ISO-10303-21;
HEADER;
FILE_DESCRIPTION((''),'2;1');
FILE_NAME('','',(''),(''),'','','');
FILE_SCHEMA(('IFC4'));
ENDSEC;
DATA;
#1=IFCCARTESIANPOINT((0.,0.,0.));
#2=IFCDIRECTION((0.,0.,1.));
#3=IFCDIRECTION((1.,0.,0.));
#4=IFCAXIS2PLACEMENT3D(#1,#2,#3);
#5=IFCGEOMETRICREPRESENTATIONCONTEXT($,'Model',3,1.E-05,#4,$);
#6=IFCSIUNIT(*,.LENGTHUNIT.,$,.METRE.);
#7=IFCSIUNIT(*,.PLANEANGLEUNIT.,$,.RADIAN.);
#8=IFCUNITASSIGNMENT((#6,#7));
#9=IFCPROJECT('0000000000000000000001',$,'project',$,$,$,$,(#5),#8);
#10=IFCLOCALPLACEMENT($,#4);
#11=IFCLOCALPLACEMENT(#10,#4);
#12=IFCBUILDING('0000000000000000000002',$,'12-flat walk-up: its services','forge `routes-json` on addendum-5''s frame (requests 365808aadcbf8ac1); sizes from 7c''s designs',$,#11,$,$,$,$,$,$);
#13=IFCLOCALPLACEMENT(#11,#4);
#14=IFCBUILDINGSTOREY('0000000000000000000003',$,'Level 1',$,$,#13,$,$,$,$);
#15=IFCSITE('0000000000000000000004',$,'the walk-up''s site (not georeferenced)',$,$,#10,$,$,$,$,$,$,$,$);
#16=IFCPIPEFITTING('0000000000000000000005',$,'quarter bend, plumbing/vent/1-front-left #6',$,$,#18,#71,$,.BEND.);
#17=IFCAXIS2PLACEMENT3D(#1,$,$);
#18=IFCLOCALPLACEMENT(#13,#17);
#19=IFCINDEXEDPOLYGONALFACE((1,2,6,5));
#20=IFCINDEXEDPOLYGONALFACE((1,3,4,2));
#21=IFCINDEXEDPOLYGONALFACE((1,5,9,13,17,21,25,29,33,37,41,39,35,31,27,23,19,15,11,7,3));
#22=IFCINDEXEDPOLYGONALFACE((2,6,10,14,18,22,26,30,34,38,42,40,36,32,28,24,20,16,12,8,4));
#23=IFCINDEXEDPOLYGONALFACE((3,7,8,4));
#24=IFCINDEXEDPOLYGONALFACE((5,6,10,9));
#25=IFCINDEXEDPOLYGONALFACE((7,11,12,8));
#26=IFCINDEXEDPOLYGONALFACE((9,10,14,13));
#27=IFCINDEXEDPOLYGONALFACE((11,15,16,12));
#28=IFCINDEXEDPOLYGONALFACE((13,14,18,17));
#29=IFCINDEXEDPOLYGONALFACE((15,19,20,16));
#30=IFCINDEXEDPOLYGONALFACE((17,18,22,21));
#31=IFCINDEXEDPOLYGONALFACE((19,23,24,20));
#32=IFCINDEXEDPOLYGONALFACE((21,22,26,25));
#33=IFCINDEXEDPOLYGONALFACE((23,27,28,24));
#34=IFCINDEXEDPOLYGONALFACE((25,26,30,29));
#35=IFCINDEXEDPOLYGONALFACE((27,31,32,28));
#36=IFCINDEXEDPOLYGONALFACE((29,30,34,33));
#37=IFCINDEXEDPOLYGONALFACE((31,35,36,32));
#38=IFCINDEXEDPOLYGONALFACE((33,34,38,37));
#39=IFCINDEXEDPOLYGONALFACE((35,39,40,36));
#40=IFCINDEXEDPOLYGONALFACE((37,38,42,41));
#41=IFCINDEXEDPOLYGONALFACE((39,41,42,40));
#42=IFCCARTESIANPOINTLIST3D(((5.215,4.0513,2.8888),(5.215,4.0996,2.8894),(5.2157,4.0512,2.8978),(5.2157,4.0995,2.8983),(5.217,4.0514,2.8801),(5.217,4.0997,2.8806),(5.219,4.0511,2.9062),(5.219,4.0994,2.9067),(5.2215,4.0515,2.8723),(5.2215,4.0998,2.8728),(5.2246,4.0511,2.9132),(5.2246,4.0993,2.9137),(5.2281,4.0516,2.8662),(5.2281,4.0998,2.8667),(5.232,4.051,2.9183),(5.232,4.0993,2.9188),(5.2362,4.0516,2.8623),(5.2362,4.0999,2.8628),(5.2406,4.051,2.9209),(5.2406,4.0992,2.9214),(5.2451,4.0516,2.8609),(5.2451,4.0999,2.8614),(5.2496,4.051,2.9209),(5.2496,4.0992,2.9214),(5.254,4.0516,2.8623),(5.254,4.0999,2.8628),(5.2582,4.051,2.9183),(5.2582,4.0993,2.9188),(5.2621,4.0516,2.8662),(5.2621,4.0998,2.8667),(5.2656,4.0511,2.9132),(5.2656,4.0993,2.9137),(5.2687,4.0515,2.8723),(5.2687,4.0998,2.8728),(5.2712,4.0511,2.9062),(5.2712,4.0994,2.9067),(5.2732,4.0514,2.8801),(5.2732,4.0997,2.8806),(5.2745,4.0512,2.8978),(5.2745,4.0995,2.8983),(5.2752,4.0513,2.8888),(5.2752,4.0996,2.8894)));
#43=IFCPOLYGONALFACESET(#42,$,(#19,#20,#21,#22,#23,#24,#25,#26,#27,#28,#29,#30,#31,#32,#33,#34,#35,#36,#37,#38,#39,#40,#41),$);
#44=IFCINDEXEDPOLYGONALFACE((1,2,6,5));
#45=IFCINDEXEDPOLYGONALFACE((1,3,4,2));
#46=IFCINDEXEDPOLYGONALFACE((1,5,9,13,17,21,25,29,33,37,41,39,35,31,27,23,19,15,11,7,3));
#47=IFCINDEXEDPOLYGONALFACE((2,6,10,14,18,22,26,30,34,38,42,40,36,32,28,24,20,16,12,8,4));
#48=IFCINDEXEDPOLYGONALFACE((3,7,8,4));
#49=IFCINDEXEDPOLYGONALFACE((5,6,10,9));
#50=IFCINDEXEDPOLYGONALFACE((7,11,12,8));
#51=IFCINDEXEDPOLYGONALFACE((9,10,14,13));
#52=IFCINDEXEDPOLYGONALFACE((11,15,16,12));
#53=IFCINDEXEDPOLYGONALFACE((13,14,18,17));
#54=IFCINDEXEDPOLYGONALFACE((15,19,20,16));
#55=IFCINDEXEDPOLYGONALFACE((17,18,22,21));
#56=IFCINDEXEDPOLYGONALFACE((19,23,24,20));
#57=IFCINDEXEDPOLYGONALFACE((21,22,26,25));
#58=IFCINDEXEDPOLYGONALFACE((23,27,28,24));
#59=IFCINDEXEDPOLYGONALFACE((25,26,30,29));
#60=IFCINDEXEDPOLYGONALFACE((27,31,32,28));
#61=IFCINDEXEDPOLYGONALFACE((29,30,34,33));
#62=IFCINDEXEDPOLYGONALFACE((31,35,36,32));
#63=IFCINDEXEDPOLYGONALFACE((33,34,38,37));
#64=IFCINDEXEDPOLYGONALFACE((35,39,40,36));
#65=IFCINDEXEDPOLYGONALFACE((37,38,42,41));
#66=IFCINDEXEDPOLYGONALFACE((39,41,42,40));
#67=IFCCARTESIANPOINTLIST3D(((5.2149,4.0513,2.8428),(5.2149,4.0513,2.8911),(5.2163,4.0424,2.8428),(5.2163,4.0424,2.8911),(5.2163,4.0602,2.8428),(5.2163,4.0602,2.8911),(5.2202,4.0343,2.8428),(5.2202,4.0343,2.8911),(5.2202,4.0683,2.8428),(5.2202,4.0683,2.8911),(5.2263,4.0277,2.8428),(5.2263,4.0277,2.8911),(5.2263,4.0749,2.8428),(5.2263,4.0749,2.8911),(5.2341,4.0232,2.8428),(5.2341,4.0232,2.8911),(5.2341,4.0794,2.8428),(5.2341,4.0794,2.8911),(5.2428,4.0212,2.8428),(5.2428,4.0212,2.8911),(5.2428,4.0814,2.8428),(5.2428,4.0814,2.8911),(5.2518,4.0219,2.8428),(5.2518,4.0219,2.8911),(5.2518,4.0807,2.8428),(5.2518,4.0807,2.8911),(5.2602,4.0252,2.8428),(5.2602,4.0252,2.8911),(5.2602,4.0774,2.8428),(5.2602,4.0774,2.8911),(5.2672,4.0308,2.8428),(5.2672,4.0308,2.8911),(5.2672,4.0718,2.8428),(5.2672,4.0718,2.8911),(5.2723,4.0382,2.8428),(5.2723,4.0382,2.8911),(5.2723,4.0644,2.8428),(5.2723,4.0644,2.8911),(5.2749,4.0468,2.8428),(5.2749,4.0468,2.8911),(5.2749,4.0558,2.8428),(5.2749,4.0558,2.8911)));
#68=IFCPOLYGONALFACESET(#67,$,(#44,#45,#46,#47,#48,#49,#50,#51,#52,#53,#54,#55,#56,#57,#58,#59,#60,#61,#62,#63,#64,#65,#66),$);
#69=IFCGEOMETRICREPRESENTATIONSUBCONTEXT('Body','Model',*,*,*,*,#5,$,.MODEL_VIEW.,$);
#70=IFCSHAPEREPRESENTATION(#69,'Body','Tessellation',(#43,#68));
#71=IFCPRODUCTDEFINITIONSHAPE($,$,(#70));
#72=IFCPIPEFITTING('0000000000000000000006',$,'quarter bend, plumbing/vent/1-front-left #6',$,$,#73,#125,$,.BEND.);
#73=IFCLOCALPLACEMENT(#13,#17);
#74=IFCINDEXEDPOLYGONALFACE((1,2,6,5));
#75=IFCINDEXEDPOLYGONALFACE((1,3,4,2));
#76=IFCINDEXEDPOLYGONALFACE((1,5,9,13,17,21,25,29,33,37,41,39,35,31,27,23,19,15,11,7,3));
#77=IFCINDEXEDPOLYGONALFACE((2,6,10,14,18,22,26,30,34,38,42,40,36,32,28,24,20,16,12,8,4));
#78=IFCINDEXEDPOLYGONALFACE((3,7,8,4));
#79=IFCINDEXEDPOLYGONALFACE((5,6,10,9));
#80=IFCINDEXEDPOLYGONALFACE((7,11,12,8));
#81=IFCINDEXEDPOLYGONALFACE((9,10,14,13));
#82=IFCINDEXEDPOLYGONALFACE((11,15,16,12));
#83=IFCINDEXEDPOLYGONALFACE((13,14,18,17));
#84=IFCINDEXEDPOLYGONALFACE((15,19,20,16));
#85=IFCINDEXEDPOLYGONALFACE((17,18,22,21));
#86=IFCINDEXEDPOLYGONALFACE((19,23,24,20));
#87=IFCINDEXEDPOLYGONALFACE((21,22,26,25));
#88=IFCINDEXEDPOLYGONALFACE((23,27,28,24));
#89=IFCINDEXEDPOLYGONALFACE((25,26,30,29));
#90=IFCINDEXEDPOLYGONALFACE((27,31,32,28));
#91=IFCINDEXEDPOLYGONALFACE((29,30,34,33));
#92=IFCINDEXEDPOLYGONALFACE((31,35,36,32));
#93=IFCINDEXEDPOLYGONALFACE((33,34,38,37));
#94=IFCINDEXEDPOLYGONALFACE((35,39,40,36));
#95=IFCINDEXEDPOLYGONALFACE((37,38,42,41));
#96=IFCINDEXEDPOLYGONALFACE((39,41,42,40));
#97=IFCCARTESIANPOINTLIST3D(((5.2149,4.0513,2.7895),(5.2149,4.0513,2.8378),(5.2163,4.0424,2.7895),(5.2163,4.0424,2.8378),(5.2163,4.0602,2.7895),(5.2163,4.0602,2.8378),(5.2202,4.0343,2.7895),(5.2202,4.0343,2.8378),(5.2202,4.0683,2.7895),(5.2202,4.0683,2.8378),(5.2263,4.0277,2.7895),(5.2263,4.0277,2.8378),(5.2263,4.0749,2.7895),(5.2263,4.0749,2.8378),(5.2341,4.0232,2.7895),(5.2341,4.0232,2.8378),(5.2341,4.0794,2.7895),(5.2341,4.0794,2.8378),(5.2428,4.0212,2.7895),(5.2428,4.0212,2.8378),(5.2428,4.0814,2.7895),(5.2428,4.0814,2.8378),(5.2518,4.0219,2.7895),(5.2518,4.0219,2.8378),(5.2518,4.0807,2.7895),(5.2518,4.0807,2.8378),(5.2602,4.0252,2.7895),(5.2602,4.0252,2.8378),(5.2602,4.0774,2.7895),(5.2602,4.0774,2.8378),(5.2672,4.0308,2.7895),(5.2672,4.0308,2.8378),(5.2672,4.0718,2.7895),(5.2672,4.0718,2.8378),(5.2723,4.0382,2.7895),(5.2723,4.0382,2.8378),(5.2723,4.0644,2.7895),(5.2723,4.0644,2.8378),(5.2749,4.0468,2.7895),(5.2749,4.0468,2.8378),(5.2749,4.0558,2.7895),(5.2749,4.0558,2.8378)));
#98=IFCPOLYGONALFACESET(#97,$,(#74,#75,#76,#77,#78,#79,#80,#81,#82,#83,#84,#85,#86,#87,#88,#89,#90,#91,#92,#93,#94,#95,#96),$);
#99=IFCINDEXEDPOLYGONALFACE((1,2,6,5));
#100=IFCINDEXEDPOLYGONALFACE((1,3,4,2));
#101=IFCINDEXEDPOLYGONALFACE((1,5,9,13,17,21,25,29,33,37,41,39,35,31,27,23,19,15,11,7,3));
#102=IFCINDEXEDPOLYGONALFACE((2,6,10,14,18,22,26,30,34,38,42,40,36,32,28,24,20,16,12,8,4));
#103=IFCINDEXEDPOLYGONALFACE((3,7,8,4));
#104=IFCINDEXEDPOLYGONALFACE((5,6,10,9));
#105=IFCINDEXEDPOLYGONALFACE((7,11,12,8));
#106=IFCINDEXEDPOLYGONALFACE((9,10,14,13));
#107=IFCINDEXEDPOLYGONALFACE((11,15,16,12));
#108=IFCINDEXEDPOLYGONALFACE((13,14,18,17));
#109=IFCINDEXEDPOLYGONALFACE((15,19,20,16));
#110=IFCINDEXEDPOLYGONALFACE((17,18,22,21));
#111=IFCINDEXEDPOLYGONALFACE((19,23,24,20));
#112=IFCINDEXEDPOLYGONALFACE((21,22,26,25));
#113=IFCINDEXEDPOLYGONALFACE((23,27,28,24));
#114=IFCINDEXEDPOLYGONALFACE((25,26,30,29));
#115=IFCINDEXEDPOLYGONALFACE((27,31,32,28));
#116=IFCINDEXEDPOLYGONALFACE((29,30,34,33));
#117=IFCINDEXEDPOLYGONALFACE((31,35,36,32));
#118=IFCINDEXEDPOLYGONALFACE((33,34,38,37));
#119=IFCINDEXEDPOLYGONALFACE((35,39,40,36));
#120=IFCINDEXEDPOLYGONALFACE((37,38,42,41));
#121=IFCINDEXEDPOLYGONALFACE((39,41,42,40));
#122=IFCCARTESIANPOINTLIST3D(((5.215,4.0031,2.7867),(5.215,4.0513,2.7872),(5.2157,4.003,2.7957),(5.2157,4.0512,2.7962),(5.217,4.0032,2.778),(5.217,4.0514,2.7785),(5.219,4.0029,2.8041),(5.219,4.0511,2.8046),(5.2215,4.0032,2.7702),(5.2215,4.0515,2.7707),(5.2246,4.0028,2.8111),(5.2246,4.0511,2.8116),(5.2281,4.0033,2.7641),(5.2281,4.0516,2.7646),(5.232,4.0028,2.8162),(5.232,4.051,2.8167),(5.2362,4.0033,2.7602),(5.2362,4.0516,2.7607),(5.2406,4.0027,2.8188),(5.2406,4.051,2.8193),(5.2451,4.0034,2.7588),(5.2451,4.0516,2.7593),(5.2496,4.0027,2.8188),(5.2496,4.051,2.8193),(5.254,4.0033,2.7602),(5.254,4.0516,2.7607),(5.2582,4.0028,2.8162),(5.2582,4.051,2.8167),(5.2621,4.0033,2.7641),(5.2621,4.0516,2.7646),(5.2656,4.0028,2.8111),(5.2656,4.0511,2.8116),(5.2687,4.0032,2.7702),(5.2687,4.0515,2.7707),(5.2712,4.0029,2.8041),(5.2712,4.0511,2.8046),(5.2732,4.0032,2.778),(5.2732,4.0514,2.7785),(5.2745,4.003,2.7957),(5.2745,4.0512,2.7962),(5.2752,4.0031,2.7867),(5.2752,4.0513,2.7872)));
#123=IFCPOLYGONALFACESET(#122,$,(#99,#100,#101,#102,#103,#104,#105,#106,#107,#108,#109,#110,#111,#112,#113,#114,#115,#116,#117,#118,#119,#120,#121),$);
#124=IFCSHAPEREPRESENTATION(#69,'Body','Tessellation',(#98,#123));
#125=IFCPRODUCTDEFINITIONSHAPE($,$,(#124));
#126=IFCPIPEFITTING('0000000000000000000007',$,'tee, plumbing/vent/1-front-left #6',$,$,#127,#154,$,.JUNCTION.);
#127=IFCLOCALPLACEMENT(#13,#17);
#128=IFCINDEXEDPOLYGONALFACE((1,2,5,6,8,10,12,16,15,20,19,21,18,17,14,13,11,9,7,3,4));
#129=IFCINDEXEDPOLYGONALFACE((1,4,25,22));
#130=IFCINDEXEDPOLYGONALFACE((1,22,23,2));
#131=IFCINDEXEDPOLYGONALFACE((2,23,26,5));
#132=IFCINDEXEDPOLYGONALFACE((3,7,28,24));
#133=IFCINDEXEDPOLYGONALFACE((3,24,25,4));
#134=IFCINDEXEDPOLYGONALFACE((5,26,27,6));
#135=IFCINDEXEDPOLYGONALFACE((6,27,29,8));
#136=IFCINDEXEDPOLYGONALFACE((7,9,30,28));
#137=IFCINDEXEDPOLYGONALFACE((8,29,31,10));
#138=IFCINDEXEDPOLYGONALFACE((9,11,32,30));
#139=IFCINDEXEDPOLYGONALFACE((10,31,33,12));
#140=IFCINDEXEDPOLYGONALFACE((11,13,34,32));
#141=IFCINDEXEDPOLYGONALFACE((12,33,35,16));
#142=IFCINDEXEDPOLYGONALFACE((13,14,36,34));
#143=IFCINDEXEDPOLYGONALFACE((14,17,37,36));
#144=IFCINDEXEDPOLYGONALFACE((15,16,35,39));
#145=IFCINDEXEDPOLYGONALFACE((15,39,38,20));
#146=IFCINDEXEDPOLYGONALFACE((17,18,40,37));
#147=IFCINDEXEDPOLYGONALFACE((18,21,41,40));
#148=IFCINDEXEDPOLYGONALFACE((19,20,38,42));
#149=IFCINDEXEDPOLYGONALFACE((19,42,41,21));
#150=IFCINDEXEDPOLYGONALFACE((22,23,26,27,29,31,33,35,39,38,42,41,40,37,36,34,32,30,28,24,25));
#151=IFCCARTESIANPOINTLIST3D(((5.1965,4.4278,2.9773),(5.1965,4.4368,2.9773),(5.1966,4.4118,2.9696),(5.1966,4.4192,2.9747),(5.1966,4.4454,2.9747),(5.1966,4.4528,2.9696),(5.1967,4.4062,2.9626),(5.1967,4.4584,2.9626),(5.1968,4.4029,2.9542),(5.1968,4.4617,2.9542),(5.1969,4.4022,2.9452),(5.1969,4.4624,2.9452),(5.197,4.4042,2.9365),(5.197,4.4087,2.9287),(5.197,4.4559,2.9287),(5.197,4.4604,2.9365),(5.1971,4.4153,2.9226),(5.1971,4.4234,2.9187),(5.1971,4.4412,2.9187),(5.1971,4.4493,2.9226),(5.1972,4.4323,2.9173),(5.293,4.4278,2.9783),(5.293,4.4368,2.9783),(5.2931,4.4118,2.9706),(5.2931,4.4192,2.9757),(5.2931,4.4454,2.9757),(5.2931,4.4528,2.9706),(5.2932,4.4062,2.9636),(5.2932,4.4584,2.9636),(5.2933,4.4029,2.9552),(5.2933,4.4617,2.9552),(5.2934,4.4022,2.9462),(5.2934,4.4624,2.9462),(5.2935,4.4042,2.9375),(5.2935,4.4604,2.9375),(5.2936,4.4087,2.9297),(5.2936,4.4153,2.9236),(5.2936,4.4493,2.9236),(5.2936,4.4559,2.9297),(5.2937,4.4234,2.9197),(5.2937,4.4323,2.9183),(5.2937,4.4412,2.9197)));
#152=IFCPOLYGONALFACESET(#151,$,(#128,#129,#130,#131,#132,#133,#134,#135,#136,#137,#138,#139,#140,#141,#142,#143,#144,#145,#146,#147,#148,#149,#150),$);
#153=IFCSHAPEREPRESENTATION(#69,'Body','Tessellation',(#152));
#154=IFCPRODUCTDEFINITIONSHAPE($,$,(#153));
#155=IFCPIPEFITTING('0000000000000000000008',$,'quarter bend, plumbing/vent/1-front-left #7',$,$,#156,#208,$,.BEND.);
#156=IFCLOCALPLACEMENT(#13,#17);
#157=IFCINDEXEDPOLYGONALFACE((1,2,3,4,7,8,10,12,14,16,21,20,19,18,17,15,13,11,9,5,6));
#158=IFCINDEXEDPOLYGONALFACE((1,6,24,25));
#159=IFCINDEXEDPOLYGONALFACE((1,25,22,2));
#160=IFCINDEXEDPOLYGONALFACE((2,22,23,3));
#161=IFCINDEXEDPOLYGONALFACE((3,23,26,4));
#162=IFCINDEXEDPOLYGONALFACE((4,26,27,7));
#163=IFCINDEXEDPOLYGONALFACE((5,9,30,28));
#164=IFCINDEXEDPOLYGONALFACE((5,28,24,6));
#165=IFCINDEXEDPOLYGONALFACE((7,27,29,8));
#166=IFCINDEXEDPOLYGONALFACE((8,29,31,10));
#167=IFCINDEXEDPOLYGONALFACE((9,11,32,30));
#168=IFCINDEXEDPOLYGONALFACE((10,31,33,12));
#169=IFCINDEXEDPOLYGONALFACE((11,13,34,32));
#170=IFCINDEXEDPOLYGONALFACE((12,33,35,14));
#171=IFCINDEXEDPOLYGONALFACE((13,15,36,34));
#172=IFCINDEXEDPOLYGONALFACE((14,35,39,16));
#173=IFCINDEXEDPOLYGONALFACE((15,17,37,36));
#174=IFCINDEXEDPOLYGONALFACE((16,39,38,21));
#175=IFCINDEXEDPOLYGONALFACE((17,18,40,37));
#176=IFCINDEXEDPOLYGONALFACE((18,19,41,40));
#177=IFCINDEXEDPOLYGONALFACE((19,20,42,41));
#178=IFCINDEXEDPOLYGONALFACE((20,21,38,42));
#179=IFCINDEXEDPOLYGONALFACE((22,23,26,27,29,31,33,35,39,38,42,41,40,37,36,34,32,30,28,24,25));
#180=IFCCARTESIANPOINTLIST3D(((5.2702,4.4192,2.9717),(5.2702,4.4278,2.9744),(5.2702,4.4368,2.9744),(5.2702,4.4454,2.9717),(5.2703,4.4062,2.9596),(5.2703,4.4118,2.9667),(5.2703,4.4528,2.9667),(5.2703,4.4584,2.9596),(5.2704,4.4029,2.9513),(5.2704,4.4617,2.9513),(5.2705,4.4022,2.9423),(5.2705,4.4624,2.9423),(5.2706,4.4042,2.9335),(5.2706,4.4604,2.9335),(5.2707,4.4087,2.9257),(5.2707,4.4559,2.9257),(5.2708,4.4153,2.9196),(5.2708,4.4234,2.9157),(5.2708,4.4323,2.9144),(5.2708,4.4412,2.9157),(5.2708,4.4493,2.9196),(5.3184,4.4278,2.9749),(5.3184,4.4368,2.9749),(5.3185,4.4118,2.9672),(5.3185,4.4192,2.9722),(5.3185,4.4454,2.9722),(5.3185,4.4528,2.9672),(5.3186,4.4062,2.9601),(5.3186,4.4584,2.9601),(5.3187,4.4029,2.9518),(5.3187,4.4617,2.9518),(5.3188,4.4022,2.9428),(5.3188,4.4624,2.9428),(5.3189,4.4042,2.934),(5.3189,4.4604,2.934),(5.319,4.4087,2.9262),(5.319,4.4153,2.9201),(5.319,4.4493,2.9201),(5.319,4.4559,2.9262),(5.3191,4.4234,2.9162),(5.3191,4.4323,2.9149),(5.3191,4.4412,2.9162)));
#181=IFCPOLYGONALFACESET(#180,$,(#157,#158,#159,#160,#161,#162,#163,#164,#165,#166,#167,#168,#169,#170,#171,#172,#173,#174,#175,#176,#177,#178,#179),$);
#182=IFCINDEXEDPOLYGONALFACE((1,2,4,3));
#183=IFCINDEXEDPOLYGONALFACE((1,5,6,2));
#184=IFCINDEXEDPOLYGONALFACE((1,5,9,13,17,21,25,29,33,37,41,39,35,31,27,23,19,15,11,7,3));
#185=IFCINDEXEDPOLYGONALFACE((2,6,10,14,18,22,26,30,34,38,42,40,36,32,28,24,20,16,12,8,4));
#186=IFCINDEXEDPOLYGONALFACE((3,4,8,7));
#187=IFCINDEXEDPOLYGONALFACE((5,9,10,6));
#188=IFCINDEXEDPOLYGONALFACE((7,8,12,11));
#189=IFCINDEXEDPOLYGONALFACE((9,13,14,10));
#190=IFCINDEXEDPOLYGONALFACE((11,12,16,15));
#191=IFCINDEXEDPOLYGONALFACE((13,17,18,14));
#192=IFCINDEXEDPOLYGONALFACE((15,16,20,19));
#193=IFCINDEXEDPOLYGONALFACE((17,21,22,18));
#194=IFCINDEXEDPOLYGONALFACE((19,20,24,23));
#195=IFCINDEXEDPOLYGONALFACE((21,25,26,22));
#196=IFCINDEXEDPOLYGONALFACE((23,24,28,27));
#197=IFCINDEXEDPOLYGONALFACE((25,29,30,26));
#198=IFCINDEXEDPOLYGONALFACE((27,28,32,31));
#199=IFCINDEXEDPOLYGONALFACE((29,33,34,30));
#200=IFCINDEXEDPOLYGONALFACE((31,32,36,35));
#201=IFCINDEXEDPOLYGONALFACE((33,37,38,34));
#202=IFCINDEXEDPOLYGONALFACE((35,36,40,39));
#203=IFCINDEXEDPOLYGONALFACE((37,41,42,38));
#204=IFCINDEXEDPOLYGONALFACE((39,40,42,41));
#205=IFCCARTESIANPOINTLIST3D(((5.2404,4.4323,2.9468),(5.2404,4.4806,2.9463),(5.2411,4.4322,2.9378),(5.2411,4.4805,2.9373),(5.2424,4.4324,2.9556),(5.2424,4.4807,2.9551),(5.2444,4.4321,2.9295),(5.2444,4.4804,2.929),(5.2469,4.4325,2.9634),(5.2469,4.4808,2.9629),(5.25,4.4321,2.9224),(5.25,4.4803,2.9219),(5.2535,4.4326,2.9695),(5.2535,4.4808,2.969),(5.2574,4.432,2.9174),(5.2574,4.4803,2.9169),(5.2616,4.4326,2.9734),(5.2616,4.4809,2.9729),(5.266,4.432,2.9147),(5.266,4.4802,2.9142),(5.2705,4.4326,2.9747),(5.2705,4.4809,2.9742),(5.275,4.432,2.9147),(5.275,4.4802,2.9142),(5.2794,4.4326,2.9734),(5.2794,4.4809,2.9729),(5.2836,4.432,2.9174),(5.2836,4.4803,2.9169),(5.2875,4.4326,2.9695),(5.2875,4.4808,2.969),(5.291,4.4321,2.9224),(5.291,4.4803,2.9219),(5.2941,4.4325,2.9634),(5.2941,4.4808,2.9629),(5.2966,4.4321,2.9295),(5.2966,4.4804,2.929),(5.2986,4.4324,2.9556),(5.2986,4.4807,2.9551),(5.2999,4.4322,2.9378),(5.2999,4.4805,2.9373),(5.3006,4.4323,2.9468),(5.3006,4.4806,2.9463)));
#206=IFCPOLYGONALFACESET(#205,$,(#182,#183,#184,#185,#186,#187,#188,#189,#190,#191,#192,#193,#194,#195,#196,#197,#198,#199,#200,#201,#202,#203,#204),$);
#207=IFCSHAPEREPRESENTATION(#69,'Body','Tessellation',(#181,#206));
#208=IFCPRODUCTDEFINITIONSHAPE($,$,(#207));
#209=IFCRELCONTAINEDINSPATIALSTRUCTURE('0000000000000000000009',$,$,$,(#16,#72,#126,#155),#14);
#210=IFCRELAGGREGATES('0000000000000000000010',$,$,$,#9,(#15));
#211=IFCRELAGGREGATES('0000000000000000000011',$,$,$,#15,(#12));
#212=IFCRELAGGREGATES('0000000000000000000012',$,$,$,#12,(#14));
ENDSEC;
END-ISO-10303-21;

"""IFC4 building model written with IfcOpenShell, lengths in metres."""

from ifc_helpers import new_model, entity, si_unit, frame, origin_with_axes, place, context, subcontext, project, spatial, element, save


model = new_model("IFC4")

# Units and contexts
model_context = context("Model", 3, precision=1e-05, world=origin_with_axes())
body_context = subcontext(model_context, "Body", "Model", "MODEL_VIEW")
ifc_project = project(units=[si_unit("LENGTHUNIT", "METRE"), si_unit("PLANEANGLEUNIT", "RADIAN")], contexts=[model_context])

# Site, building, storey
site_placement = place(None, origin_with_axes())
site = spatial("IfcSite", under=ifc_project, at=site_placement, Name="the walk-up's site (not georeferenced)")
building_placement = place(site_placement, origin_with_axes())
building = spatial("IfcBuilding", under=site, at=building_placement, Name="12-flat walk-up: its services", Description="forge `routes-json` on addendum-5's frame (requests 365808aadcbf8ac1); sizes from 7c's designs")
storey_placement = place(building_placement, origin_with_axes())
storey = spatial("IfcBuildingStorey", under=building, at=storey_placement, Name="Level 1")

# Pipe fittings
pipe_fitting_1_placement = place(storey_placement, frame((5.2451, 4.0996, 2.8916), z_axis=(0.0, 0.0, 1.0), x_axis=(1.0, 0.0, 0.0)))
element("IfcPipeFitting", 1, at=pipe_fitting_1_placement, inside=storey, Name="quarter bend, plumbing/vent/1-front-left #6", PredefinedType="BEND", context=body_context, shape_type="AdvancedSweptSolid", body=[
    entity("IfcSweptDiskSolid", entity("IfcPolyline", [entity("IfcCartesianPoint", [0.0, 0.0, 0.0]), entity("IfcCartesianPoint", [0.0, -0.0483, -0.0005])]), 0.0302),
    entity("IfcSweptDiskSolid", entity("IfcPolyline", [entity("IfcCartesianPoint", [0.0, -0.0483, -0.0005]), entity("IfcCartesianPoint", [0.0, -0.0483, -0.0488])]), 0.0302),
])
pipe_fitting_2_placement = place(storey_placement, frame((5.2451, 4.0513, 2.8378), z_axis=(0.0, 0.0, 1.0), x_axis=(1.0, 0.0, 0.0)))
element("IfcPipeFitting", 2, at=pipe_fitting_2_placement, inside=storey, Name="quarter bend, plumbing/vent/1-front-left #6", PredefinedType="BEND", context=body_context, shape_type="AdvancedSweptSolid", body=[
    entity("IfcSweptDiskSolid", entity("IfcPolyline", [entity("IfcCartesianPoint", [0.0, 0.0, 0.0]), entity("IfcCartesianPoint", [0.0, 0.0, -0.0483])]), 0.0302),
    entity("IfcSweptDiskSolid", entity("IfcPolyline", [entity("IfcCartesianPoint", [0.0, 0.0, -0.0483]), entity("IfcCartesianPoint", [0.0, -0.0483, -0.0488])]), 0.0302),
])
pipe_fitting_3_placement = place(storey_placement, frame((5.2934, 4.4323, 2.9485), z_axis=(0.0, 0.0, 1.0), x_axis=(1.0, 0.0, 0.0)))
element("IfcPipeFitting", 3, at=pipe_fitting_3_placement, inside=storey, Name="tee, plumbing/vent/1-front-left #6", PredefinedType="JUNCTION", context=body_context, shape_type="AdvancedSweptSolid", body=[
    entity("IfcSweptDiskSolid", entity("IfcPolyline", [entity("IfcCartesianPoint", [0.0, 0.0, 0.0]), entity("IfcCartesianPoint", [-0.0965, 0.0, -0.001])]), 0.0302),
])

# Pipe fitting
pipe_fitting_4_placement = place(storey_placement, frame((5.3188, 4.4323, 2.9451), z_axis=(0.0, 0.0, 1.0), x_axis=(1.0, 0.0, 0.0)))
element("IfcPipeFitting", 4, at=pipe_fitting_4_placement, inside=storey, Name="quarter bend, plumbing/vent/1-front-left #7", PredefinedType="BEND", context=body_context, shape_type="AdvancedSweptSolid", body=[
    entity("IfcSweptDiskSolid", entity("IfcPolyline", [entity("IfcCartesianPoint", [0.0, 0.0, 0.0]), entity("IfcCartesianPoint", [-0.0483, 0.0, -0.0005])]), 0.0302),
    entity("IfcSweptDiskSolid", entity("IfcPolyline", [entity("IfcCartesianPoint", [-0.0483, 0.0, -0.0005]), entity("IfcCartesianPoint", [-0.0483, 0.0483, -0.001])]), 0.0302),
])

save(model, "model.ifc")
